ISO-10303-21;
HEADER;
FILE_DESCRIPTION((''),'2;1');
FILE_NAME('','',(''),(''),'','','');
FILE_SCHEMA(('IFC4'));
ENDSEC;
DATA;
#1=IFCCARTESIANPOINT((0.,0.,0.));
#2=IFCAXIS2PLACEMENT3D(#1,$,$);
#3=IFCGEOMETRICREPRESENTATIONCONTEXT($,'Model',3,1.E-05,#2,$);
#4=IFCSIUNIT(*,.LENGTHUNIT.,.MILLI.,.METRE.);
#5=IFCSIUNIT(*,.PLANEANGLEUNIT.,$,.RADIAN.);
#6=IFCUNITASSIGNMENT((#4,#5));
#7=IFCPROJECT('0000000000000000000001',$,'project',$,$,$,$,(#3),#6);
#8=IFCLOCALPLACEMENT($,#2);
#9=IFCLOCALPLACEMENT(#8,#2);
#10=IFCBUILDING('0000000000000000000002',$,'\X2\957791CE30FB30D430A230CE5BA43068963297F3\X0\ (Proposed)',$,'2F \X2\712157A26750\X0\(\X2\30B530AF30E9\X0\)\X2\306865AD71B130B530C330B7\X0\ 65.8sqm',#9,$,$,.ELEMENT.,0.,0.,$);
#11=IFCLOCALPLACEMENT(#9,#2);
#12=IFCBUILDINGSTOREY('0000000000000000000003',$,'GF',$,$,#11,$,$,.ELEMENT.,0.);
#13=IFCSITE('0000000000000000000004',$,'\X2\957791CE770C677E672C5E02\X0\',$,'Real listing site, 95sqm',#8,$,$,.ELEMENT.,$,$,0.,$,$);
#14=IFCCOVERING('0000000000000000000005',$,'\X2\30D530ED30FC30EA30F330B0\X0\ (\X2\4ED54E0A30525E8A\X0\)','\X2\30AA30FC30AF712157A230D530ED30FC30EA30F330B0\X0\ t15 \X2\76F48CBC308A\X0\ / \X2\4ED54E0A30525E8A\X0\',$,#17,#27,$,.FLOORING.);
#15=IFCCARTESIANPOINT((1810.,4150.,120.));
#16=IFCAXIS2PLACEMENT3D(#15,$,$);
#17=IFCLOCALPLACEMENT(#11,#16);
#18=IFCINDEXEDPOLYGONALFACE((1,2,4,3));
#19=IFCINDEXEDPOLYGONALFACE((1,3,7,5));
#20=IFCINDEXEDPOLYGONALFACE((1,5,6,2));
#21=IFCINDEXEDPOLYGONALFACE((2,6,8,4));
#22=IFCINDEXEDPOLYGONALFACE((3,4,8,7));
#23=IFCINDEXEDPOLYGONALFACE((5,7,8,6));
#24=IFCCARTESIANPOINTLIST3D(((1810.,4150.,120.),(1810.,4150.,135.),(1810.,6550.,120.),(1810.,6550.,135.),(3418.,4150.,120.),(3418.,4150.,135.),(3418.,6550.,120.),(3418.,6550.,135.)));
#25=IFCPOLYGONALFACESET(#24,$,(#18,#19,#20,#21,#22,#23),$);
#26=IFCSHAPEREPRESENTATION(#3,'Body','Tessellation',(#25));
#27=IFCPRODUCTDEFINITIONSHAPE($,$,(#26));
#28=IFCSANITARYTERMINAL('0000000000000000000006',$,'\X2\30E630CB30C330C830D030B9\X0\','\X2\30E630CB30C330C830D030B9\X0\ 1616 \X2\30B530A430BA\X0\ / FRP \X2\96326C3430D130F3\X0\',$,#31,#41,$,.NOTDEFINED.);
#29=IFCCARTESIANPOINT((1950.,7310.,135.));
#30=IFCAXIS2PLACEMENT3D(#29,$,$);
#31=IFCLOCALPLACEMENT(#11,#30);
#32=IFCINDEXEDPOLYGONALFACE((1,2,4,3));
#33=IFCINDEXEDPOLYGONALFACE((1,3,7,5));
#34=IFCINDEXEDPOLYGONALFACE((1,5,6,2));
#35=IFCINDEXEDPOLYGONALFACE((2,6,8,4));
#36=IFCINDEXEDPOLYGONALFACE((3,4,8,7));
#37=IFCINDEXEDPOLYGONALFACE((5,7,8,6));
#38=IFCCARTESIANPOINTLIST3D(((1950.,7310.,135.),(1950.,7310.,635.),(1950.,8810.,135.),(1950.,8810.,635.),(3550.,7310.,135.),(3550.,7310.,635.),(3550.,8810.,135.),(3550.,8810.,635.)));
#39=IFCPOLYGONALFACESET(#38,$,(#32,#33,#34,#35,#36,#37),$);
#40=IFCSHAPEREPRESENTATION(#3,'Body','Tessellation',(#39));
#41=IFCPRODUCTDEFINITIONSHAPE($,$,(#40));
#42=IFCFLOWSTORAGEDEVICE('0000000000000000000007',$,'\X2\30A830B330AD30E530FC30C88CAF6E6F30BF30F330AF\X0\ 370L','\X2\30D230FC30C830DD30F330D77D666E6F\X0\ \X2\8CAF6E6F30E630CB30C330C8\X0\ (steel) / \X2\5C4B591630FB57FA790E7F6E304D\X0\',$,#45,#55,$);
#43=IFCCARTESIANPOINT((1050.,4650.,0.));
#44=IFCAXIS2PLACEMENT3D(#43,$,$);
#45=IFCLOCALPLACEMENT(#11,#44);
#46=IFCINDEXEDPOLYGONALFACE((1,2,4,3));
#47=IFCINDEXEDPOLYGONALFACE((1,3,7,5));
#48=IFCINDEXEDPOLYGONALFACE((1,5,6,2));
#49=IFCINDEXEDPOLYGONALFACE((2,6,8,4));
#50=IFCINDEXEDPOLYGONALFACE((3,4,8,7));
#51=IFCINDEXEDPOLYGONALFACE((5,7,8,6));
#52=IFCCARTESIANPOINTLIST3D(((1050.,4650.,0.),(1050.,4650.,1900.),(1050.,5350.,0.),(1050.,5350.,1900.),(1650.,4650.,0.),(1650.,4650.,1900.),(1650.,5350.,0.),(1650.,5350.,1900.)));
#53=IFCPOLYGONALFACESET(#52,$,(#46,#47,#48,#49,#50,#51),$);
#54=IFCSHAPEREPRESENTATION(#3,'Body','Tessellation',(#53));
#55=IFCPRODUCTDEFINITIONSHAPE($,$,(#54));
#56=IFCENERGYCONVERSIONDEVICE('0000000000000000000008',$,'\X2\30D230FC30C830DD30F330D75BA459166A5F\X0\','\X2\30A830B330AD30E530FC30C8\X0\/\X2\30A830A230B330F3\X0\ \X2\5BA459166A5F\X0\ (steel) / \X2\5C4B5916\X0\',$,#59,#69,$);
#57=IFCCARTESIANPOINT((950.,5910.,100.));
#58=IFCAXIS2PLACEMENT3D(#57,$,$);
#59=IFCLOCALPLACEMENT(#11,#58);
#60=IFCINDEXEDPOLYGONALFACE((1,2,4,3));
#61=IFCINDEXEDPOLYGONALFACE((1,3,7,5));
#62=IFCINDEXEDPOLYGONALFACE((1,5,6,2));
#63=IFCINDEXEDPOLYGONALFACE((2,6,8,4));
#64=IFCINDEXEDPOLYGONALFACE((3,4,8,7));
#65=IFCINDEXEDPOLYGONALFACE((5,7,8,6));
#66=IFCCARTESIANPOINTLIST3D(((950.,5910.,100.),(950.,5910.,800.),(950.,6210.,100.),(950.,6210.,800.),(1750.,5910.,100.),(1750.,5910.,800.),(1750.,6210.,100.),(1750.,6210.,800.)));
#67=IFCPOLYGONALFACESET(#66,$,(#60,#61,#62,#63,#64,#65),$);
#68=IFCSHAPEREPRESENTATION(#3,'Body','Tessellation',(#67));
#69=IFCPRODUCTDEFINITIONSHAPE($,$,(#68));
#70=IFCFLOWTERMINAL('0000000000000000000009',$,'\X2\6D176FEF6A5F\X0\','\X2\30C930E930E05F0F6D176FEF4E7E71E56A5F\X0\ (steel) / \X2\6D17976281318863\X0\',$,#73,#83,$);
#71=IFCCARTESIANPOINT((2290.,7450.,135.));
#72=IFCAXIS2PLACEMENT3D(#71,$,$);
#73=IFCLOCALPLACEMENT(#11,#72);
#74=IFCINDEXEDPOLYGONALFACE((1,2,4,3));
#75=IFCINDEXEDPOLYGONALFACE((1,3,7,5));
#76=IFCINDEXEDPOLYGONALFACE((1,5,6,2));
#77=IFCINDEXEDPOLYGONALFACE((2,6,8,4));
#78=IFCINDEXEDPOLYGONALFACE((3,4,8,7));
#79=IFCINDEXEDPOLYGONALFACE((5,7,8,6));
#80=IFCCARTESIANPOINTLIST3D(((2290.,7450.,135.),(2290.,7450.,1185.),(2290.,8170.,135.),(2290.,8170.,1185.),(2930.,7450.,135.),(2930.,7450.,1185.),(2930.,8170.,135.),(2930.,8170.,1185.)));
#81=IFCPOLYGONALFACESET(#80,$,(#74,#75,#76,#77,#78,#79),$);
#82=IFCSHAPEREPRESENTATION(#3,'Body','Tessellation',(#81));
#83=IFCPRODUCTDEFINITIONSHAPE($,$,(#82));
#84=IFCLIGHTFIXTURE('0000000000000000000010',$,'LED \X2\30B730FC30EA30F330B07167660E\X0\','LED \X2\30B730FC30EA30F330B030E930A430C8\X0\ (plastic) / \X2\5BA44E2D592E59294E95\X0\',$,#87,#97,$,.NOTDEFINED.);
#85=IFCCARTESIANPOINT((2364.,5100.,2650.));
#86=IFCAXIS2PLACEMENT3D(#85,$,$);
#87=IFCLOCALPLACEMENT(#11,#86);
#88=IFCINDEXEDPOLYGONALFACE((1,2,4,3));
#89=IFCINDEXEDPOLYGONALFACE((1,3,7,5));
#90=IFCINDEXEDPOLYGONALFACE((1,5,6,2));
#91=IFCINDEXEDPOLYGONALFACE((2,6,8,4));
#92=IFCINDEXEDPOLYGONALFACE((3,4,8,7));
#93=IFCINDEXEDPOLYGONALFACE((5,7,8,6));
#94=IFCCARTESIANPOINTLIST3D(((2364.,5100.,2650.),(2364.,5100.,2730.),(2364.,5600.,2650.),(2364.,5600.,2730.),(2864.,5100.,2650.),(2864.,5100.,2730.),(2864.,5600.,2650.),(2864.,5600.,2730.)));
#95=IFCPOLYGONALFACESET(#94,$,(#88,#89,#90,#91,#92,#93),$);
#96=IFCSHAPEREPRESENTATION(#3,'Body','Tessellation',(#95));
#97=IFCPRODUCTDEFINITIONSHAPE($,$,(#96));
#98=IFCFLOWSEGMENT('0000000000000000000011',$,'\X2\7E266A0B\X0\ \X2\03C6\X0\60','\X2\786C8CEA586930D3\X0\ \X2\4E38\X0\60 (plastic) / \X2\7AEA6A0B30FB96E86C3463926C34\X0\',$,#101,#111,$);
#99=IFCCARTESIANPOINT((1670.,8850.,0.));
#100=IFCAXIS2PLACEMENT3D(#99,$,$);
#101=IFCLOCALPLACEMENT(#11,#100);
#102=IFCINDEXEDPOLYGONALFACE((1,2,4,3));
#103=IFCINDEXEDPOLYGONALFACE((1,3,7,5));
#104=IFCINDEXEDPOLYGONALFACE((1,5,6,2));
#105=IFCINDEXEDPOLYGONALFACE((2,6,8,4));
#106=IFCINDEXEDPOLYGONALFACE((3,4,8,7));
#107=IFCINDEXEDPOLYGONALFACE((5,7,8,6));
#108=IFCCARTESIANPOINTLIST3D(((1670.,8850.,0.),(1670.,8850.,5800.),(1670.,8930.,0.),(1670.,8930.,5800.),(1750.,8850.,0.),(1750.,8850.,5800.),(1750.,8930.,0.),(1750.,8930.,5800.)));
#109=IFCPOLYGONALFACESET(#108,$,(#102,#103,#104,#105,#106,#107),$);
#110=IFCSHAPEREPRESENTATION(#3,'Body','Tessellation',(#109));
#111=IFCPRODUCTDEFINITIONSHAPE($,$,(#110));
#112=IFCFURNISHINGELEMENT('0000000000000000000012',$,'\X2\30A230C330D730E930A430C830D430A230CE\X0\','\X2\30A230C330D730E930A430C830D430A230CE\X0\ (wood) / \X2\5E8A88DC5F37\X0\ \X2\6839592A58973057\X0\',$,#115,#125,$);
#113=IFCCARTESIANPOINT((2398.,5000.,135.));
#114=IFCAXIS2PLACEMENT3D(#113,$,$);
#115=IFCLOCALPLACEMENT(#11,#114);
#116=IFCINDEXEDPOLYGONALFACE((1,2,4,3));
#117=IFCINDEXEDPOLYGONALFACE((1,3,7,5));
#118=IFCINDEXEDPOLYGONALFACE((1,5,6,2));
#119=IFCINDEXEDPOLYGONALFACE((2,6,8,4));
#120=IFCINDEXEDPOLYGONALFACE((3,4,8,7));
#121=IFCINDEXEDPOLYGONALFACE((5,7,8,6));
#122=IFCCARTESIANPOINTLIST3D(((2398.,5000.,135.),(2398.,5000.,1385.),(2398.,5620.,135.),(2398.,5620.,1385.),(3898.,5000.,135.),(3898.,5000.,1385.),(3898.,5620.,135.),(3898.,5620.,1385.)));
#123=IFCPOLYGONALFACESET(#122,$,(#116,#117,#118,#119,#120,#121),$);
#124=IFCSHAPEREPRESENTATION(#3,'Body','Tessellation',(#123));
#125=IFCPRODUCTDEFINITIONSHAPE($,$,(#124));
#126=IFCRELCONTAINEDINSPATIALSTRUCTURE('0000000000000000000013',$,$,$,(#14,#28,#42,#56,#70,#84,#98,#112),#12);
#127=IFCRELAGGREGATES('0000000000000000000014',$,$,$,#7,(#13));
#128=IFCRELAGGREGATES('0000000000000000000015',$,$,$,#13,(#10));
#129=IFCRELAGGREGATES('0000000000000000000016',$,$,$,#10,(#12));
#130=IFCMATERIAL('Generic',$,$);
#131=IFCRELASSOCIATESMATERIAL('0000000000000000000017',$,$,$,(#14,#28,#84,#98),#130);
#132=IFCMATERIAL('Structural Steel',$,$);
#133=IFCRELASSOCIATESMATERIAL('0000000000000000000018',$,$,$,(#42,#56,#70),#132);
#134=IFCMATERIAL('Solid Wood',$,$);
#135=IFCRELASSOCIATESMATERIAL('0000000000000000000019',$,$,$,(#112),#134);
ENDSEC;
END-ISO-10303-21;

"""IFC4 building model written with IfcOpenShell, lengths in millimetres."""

from ifc_helpers import new_model, si_unit, frame, frame_2d, origin, place, context, project, spatial, rectangle, extrude, material, element, save


model = new_model("IFC4")

# Units and contexts
model_context = context("Model", 3, precision=1e-05, world=origin())
ifc_project = project(units=[si_unit("LENGTHUNIT", "METRE", prefix="MILLI"), si_unit("PLANEANGLEUNIT", "RADIAN")], contexts=[model_context])

# Site, building, storey
site_placement = place(None, origin())
site = spatial("IfcSite", under=ifc_project, at=site_placement, Name="長野県松本市", ObjectType="Real listing site, 95sqm", CompositionType="ELEMENT", RefElevation=0.0)
building_placement = place(site_placement, origin())
building = spatial("IfcBuilding", under=site, at=building_placement, Name="長野・ピアノ室と防音 (Proposed)", ObjectType="2F 無垢材(サクラ)と断熱サッシ 65.8sqm", CompositionType="ELEMENT", ElevationOfRefHeight=0.0, ElevationOfTerrain=0.0)
storey_placement = place(building_placement, origin())
storey = spatial("IfcBuildingStorey", under=building, at=storey_placement, Name="GF", CompositionType="ELEMENT", Elevation=0.0)

# Shared definitions
ifc_material_1 = material(Name="Solid Wood")

# Covering
ifc_material_2 = material(Name="Generic")
covering_1_placement = place(storey_placement, frame((1810.0, 4150.0, 120.0)))
element("IfcCovering", 1, at=covering_1_placement, inside=storey, material=ifc_material_2, Name="フローリング (仕上げ床)", Description="オーク無垢フローリング t15 直貼り / 仕上げ床", PredefinedType="FLOORING", context=model_context, shape_type="SweptSolid", body=[
    extrude(rectangle(XDim=1608.0, YDim=2400.0, at=frame_2d((804.0, 1200.0))), frame((1810.0, 4150.0, 120.0)), (0.0, 0.0, 1.0), 15.0),
])

# Sanitary terminal
sanitary_terminal_placement = place(storey_placement, frame((1950.0, 7310.0, 135.0)))
element("IfcSanitaryTerminal", 2, at=sanitary_terminal_placement, inside=storey, material=ifc_material_2, Name="ユニットバス", Description="ユニットバス 1616 サイズ / FRP 防水パン", PredefinedType="NOTDEFINED", context=model_context, shape_type="SweptSolid", body=[
    extrude(rectangle(XDim=1600.0, YDim=1500.0, at=frame_2d((800.0, 750.0))), frame((1950.0, 7310.0, 135.0)), (0.0, 0.0, 1.0), 500.0),
])

# Flow storage device
ifc_material_3 = material(Name="Structural Steel")
flow_storage_device_placement = place(storey_placement, frame((1050.0, 4650.0, 0.0)))
element("IfcFlowStorageDevice", 3, at=flow_storage_device_placement, inside=storey, material=ifc_material_3, Name="エコキュート貯湯タンク 370L", Description="ヒートポンプ給湯 貯湯ユニット (steel) / 屋外・基礎置き", context=model_context, shape_type="SweptSolid", body=[
    extrude(rectangle(XDim=600.0, YDim=700.0, at=frame_2d((300.0, 350.0))), frame((1050.0, 4650.0, 0.0)), (0.0, 0.0, 1.0), 1900.0),
])

# Energy conversion device
energy_conversion_device_placement = place(storey_placement, frame((950.0, 5910.0, 100.0)))
element("IfcEnergyConversionDevice", 4, at=energy_conversion_device_placement, inside=storey, material=ifc_material_3, Name="ヒートポンプ室外機", Description="エコキュート/エアコン 室外機 (steel) / 屋外", context=model_context, shape_type="SweptSolid", body=[
    extrude(rectangle(XDim=800.0, YDim=300.0, at=frame_2d((400.0, 150.0))), frame((950.0, 5910.0, 100.0)), (0.0, 0.0, 1.0), 700.0),
])

# Flow terminal
flow_terminal_placement = place(storey_placement, frame((2290.0, 7450.0, 135.0)))
element("IfcFlowTerminal", 5, at=flow_terminal_placement, inside=storey, material=ifc_material_3, Name="洗濯機", Description="ドラム式洗濯乾燥機 (steel) / 洗面脱衣", context=model_context, shape_type="SweptSolid", body=[
    extrude(rectangle(XDim=640.0, YDim=720.0, at=frame_2d((320.0, 360.0))), frame((2290.0, 7450.0, 135.0)), (0.0, 0.0, 1.0), 1050.0),
])

# Light fixture
light_fixture_placement = place(storey_placement, frame((2364.0, 5100.0, 2650.0)))
element("IfcLightFixture", 6, at=light_fixture_placement, inside=storey, material=ifc_material_2, Name="LED シーリング照明", Description="LED シーリングライト (plastic) / 室中央天井", PredefinedType="NOTDEFINED", context=model_context, shape_type="SweptSolid", body=[
    extrude(rectangle(XDim=500.0, YDim=500.0, at=frame_2d((250.0, 250.0))), frame((2364.0, 5100.0, 2650.0)), (0.0, 0.0, 1.0), 80.0),
])

# Flow segment
flow_segment_placement = place(storey_placement, frame((1670.0, 8850.0, 0.0)))
element("IfcFlowSegment", 7, at=flow_segment_placement, inside=storey, material=ifc_material_2, Name="縦樋 φ60", Description="硬質塩ビ 丸60 (plastic) / 竪樋・雨水排水", context=model_context, shape_type="SweptSolid", body=[
    extrude(rectangle(XDim=80.0, YDim=80.0, at=frame_2d((40.0, 40.0))), frame((1670.0, 8850.0, 0.0)), (0.0, 0.0, 1.0), 5800.0),
])

# Furnishing element
furnishing_placement = place(storey_placement, frame((2398.0, 5000.0, 135.0)))
element("IfcFurnishingElement", 8, at=furnishing_placement, inside=storey, material=ifc_material_1, Name="アップライトピアノ", Description="アップライトピアノ (wood) / 床補強 根太増し", context=model_context, shape_type="SweptSolid", body=[
    extrude(rectangle(XDim=1500.0, YDim=620.0, at=frame_2d((750.0, 310.0))), frame((2398.0, 5000.0, 135.0)), (0.0, 0.0, 1.0), 1250.0),
])

save(model, "model.ifc")
